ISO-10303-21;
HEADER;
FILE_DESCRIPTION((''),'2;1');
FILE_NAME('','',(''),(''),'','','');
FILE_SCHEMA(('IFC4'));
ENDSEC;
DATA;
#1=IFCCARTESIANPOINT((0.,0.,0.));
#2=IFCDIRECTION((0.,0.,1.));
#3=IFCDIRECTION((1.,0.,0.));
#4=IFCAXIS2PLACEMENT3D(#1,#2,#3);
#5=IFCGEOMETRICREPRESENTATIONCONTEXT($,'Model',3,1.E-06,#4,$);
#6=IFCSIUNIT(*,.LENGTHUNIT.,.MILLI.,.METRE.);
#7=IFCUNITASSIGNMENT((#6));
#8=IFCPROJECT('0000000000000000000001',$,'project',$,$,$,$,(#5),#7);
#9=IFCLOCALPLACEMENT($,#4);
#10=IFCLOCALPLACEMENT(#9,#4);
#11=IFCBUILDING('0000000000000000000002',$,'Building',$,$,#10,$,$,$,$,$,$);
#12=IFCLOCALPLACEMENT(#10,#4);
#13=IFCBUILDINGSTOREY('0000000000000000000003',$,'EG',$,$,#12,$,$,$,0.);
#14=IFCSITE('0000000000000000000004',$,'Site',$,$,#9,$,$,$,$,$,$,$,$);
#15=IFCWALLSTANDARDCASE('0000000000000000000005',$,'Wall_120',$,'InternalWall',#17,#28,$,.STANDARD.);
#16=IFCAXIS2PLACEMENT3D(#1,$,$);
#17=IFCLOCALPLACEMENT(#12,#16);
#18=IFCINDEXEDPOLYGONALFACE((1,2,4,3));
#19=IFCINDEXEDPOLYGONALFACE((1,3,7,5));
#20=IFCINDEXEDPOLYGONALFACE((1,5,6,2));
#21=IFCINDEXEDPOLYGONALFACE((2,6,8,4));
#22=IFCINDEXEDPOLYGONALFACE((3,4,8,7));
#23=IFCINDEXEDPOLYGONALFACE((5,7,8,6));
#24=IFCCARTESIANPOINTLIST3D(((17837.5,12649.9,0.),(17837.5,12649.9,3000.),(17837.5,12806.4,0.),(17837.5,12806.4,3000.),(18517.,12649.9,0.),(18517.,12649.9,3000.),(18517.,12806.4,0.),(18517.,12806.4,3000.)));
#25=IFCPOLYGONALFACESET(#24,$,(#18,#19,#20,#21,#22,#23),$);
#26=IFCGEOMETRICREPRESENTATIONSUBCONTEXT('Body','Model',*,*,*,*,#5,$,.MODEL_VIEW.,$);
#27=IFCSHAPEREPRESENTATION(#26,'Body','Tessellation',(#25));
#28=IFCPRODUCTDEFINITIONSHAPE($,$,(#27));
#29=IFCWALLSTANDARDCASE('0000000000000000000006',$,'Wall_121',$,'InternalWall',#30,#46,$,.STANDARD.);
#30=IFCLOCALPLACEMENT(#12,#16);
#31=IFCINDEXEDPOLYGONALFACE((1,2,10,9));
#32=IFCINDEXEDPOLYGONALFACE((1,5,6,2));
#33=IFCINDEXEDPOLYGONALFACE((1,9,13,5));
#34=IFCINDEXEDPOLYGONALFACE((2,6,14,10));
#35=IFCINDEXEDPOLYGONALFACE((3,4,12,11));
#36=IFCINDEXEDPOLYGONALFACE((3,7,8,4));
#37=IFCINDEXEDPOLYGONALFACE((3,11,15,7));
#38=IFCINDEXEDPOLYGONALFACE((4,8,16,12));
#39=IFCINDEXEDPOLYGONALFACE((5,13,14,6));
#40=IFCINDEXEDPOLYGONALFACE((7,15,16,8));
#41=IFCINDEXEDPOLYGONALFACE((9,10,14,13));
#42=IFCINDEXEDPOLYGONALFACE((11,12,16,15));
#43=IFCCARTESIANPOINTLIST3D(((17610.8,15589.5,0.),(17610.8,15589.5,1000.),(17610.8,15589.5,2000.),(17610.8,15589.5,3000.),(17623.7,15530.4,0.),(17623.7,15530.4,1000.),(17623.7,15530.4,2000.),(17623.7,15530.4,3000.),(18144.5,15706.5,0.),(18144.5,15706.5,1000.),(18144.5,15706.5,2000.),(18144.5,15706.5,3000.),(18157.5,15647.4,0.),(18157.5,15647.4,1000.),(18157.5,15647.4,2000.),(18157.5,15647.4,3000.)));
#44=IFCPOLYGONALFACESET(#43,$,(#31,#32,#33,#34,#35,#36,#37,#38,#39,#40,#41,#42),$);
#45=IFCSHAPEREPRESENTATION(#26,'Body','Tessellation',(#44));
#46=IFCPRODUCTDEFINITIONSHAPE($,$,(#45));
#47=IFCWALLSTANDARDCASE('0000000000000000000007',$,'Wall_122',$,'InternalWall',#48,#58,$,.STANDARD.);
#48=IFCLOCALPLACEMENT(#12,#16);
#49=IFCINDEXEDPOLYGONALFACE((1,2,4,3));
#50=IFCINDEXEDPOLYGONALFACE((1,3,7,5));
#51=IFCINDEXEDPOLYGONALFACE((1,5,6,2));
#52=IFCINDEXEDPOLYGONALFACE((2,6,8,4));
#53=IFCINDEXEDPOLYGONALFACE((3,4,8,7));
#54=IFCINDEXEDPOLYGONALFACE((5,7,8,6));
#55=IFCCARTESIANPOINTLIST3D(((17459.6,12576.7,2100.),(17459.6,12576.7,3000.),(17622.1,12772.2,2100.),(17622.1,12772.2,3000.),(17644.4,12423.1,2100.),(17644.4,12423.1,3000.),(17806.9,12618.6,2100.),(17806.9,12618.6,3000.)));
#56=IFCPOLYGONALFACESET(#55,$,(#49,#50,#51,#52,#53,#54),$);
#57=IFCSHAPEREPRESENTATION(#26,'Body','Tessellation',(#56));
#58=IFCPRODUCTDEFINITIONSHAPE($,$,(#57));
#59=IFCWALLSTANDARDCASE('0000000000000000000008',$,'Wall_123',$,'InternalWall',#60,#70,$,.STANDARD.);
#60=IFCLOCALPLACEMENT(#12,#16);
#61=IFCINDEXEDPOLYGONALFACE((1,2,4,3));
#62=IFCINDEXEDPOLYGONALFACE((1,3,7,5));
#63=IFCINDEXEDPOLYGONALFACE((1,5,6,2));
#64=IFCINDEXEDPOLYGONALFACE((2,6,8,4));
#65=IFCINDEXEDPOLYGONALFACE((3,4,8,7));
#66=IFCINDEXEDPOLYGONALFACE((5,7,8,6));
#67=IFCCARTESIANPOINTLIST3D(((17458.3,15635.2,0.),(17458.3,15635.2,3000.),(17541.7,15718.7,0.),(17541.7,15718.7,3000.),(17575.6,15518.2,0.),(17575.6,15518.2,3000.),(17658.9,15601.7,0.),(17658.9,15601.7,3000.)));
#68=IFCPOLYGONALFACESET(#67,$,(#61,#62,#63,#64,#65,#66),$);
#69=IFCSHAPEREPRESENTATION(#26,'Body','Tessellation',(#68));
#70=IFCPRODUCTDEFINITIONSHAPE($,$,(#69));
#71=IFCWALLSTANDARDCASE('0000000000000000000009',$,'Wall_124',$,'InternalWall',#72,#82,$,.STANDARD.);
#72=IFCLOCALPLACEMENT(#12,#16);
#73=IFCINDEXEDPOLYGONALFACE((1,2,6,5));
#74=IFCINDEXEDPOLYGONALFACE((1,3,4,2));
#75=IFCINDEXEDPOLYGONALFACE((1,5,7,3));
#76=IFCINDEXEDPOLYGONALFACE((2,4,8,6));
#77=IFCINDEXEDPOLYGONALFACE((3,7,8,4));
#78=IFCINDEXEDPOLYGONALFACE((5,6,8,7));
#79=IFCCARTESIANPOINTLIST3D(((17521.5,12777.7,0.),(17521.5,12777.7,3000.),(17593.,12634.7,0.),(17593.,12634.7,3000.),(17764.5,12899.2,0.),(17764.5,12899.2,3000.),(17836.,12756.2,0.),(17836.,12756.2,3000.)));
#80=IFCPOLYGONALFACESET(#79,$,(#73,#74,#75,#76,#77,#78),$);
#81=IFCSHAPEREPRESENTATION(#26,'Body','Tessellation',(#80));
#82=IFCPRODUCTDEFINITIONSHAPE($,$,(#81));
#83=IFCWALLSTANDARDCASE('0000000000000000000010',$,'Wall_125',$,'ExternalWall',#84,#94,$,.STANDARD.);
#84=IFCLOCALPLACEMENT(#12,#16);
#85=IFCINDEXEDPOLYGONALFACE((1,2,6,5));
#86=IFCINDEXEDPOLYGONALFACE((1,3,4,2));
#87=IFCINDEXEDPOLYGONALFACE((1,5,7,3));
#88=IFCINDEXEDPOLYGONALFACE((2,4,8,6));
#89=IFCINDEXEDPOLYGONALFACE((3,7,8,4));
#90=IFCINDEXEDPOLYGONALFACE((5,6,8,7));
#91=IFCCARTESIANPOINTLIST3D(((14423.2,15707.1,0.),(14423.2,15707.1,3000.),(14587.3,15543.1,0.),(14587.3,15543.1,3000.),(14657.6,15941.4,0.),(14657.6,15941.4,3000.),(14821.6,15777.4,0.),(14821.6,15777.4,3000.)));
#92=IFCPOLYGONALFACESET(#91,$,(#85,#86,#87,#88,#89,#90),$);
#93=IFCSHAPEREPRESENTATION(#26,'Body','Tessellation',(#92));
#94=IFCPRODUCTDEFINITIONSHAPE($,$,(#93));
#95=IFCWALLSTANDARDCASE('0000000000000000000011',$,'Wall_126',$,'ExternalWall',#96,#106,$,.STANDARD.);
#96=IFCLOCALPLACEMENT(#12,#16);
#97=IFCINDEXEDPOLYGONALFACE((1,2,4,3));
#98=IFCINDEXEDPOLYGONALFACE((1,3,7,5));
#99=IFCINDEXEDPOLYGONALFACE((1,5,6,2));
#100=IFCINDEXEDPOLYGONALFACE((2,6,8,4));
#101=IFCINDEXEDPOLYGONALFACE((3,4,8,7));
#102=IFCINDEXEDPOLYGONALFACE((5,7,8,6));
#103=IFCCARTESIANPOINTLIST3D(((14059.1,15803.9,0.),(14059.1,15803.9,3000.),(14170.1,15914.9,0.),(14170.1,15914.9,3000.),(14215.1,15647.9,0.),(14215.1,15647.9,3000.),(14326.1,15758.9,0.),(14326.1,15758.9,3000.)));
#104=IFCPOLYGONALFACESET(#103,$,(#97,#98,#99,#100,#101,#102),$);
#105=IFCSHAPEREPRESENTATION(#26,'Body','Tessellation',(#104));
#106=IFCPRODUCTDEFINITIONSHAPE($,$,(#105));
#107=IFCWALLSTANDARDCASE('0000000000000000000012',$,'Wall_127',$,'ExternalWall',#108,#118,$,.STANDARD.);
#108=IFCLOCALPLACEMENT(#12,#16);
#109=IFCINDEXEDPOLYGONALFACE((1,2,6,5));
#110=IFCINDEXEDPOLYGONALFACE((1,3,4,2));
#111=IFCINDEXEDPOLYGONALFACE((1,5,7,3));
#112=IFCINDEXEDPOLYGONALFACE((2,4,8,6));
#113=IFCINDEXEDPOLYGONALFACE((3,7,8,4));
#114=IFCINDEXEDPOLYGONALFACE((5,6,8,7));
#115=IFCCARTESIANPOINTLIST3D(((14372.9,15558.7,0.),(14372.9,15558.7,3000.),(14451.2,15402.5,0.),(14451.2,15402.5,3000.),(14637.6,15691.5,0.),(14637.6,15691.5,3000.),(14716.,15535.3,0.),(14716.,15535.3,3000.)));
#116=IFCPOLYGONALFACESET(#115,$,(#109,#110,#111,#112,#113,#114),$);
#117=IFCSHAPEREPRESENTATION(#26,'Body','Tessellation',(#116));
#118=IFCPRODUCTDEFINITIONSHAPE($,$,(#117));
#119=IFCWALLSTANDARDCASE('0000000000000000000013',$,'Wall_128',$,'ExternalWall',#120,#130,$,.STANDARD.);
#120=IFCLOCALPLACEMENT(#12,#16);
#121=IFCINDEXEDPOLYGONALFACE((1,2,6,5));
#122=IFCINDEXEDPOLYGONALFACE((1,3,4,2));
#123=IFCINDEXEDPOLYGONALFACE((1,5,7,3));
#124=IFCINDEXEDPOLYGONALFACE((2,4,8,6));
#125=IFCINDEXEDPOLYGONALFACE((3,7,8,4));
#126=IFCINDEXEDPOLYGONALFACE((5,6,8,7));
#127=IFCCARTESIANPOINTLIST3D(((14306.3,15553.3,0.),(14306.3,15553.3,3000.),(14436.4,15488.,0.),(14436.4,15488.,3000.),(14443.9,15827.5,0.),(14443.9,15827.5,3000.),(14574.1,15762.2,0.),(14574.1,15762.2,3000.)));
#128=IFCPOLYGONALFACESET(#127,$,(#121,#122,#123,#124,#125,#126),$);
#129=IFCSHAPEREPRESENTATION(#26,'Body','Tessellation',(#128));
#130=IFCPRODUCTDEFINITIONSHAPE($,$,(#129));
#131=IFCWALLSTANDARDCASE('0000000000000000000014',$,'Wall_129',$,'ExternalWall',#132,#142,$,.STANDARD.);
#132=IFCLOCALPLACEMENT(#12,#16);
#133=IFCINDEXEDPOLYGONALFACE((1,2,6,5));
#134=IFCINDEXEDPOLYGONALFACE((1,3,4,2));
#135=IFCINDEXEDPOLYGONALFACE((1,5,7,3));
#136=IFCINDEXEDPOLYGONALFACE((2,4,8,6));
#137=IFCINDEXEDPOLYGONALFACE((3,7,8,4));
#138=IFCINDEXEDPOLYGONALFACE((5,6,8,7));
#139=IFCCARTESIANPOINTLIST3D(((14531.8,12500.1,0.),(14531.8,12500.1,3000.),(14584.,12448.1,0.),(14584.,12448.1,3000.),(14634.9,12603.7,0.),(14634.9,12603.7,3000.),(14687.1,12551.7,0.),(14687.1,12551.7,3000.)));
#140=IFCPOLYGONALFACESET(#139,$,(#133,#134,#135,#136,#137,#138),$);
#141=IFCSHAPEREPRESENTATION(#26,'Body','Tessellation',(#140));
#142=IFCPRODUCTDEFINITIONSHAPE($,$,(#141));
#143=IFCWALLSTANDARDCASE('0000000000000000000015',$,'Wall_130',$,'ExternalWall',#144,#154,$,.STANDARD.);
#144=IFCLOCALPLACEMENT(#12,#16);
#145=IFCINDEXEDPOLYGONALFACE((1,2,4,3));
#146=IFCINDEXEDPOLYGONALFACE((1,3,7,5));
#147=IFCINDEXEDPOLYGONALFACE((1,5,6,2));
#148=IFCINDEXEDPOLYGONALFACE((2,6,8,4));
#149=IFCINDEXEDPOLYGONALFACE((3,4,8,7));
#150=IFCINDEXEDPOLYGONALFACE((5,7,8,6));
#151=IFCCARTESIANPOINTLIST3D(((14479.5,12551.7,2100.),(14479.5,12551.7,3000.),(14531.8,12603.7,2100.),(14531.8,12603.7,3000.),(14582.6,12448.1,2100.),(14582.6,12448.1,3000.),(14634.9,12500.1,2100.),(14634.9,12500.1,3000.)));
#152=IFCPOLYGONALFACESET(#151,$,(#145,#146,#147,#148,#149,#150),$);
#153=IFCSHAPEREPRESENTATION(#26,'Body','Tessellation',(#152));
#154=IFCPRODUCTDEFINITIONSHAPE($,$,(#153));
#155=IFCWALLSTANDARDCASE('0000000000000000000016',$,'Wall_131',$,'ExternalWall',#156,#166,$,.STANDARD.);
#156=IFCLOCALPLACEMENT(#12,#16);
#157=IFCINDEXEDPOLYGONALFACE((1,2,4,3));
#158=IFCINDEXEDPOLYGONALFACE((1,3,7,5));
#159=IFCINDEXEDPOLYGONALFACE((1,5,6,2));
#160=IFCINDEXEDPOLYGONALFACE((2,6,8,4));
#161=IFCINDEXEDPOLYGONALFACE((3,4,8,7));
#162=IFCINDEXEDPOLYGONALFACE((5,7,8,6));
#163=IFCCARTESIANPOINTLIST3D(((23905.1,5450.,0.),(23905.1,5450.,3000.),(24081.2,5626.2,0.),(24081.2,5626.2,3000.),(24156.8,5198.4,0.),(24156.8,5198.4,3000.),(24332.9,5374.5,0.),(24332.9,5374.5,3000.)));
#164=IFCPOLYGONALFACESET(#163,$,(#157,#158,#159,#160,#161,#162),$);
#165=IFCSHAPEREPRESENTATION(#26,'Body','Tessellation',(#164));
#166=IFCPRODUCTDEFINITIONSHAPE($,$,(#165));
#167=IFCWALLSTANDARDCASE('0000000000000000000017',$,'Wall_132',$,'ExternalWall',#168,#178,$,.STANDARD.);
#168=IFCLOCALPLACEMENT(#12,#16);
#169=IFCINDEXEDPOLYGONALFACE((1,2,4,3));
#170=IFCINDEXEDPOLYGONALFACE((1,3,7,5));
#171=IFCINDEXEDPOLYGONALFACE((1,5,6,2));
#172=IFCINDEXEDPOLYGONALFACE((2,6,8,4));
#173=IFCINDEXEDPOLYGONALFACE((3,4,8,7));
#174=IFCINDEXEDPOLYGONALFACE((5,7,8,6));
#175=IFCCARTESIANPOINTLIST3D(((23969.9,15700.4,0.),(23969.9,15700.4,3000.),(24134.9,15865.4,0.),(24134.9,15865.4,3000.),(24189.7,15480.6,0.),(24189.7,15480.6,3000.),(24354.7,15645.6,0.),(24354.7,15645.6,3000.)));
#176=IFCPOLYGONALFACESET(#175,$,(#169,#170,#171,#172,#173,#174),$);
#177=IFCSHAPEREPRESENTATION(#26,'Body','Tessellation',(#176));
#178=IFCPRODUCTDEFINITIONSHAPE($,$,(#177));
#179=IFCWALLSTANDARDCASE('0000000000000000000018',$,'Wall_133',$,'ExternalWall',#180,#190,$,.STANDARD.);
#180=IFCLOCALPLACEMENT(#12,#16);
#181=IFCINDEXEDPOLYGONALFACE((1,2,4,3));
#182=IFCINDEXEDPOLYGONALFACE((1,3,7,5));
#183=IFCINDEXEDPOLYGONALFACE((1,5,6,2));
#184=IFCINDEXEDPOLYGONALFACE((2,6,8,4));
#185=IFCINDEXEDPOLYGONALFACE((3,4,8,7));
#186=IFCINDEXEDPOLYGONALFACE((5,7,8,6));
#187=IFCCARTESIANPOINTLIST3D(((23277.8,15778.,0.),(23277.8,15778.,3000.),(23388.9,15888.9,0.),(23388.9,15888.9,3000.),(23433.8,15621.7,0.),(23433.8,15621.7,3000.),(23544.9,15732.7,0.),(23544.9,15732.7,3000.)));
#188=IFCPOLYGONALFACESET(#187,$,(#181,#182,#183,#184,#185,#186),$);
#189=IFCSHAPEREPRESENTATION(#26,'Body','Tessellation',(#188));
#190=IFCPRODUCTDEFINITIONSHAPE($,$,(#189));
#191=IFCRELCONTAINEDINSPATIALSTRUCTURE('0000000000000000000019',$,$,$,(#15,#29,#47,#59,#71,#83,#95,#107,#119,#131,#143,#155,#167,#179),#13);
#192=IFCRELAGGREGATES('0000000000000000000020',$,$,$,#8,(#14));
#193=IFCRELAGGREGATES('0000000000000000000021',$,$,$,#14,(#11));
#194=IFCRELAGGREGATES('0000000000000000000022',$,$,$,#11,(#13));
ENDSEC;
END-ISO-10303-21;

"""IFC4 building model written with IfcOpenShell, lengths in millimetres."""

from ifc_helpers import new_model, si_unit, frame, origin_with_axes, place, context, subcontext, project, spatial, rectangle, extrude, element, save


model = new_model("IFC4")

# Units and contexts
model_context = context("Model", 3, precision=1e-06, world=origin_with_axes())
body_context = subcontext(model_context, "Body", "Model", "MODEL_VIEW")
ifc_project = project(units=[si_unit("LENGTHUNIT", "METRE", prefix="MILLI")], contexts=[model_context])

# Site, building, storey
site_placement = place(None, origin_with_axes())
site = spatial("IfcSite", under=ifc_project, at=site_placement, Name="Site")
building_placement = place(site_placement, origin_with_axes())
building = spatial("IfcBuilding", under=site, at=building_placement, Name="Building")
storey_placement = place(building_placement, origin_with_axes())
storey = spatial("IfcBuildingStorey", under=building, at=storey_placement, Name="EG", Elevation=0.0)

# Wall
wall_1_placement = place(storey_placement, origin_with_axes())
element("IfcWallStandardCase", 1, at=wall_1_placement, inside=storey, Name="Wall_120", ObjectType="InternalWall", PredefinedType="STANDARD", context=body_context, shape_type="SweptSolid", body=[
    extrude(rectangle(XDim=679.6, YDim=156.5), frame((18177.3, 12728.2, 0.0), z_axis=(0.0, 0.0, 1.0), x_axis=(-1.0, 0.0, 0.0)), (0.0, 0.0, 1.0), 3000.0),
])

# Walls, openings
wall_2_placement = place(storey_placement, origin_with_axes())
wall_2 = element("IfcWallStandardCase", 2, at=wall_2_placement, inside=storey, Name="Wall_121", ObjectType="InternalWall", PredefinedType="STANDARD", context=body_context, shape_type="SweptSolid", body=[
    extrude(rectangle(XDim=546.4, YDim=60.5), frame((17884.1, 15618.4, 0.0), z_axis=(0.0, 0.0, 1.0), x_axis=(0.976807, 0.21412, 0.0)), (0.0, 0.0, 1.0), 3000.0),
])
opening_1_placement = place(wall_2_placement, origin_with_axes())
element("IfcOpeningElement", 3, at=opening_1_placement, inside=storey, cuts=wall_2, context=body_context, shape_type="SweptSolid", body=[
    extrude(rectangle(XDim=600.0, YDim=60.5), frame((17884.1, 15618.4, 1000.0), z_axis=(0.0, 0.0, 1.0), x_axis=(0.976807, 0.21412, 0.0)), (0.0, 0.0, 1.0), 1000.0),
])
wall_3_placement = place(storey_placement, origin_with_axes())
wall_3 = element("IfcWallStandardCase", 4, at=wall_3_placement, inside=storey, Name="Wall_122", ObjectType="InternalWall", PredefinedType="STANDARD", context=body_context, shape_type="SweptSolid", body=[
    extrude(rectangle(XDim=254.2, YDim=240.3), frame((17633.3, 12597.7, 0.0), z_axis=(0.0, 0.0, 1.0), x_axis=(-0.639217, -0.769027, 0.0)), (0.0, 0.0, 1.0), 3000.0),
])
opening_2_placement = place(wall_3_placement, origin_with_axes())
element("IfcOpeningElement", 5, at=opening_2_placement, inside=storey, cuts=wall_3, context=body_context, shape_type="SweptSolid", body=[
    extrude(rectangle(XDim=450.0, YDim=240.3), frame((17633.3, 12597.7, 0.0), z_axis=(0.0, 0.0, 1.0), x_axis=(-0.639217, -0.769027, 0.0)), (0.0, 0.0, 1.0), 2100.0),
])

# Walls
wall_4_placement = place(storey_placement, origin_with_axes())
element("IfcWallStandardCase", 6, at=wall_4_placement, inside=storey, Name="Wall_123", ObjectType="InternalWall", PredefinedType="STANDARD", context=body_context, shape_type="SweptSolid", body=[
    extrude(rectangle(XDim=165.6, YDim=118.0), frame((17558.6, 15618.4, 0.0), z_axis=(0.0, 0.0, 1.0), x_axis=(-0.707861, 0.706352, 0.0)), (0.0, 0.0, 1.0), 3000.0),
])
wall_5_placement = place(storey_placement, origin_with_axes())
element("IfcWallStandardCase", 7, at=wall_5_placement, inside=storey, Name="Wall_124", ObjectType="InternalWall", PredefinedType="STANDARD", context=body_context, shape_type="SweptSolid", body=[
    extrude(rectangle(XDim=159.9, YDim=271.7), frame((17678.8, 12766.9, 0.0), z_axis=(0.0, 0.0, 1.0), x_axis=(0.447214, -0.894427, 0.0)), (0.0, 0.0, 1.0), 3000.0),
])
wall_6_placement = place(storey_placement, origin_with_axes())
element("IfcWallStandardCase", 8, at=wall_6_placement, inside=storey, Name="Wall_125", ObjectType="ExternalWall", PredefinedType="STANDARD", context=body_context, shape_type="SweptSolid", body=[
    extrude(rectangle(XDim=331.4, YDim=231.9), frame((14622.4, 15742.3, 0.0), z_axis=(0.0, 0.0, 1.0), x_axis=(0.707107, 0.707107, 0.0)), (0.0, 0.0, 1.0), 3000.0),
])
wall_7_placement = place(storey_placement, origin_with_axes())
element("IfcWallStandardCase", 9, at=wall_7_placement, inside=storey, Name="Wall_126", ObjectType="ExternalWall", PredefinedType="STANDARD", context=body_context, shape_type="SweptSolid", body=[
    extrude(rectangle(XDim=220.6, YDim=157.0), frame((14192.6, 15781.4, 0.0), z_axis=(0.0, 0.0, 1.0), x_axis=(-0.707107, 0.707107, 0.0)), (0.0, 0.0, 1.0), 3000.0),
])
wall_8_placement = place(storey_placement, origin_with_axes())
element("IfcWallStandardCase", 10, at=wall_8_placement, inside=storey, Name="Wall_127", ObjectType="ExternalWall", PredefinedType="STANDARD", context=body_context, shape_type="SweptSolid", body=[
    extrude(rectangle(XDim=174.7, YDim=296.2), frame((14544.4, 15547.0, 0.0), z_axis=(0.0, 0.0, 1.0), x_axis=(-0.448358, 0.893854, 0.0)), (0.0, 0.0, 1.0), 3000.0),
])
wall_9_placement = place(storey_placement, origin_with_axes())
element("IfcWallStandardCase", 11, at=wall_9_placement, inside=storey, Name="Wall_128", ObjectType="ExternalWall", PredefinedType="STANDARD", context=body_context, shape_type="SweptSolid", body=[
    extrude(rectangle(XDim=145.6, YDim=306.8), frame((14440.2, 15657.8, 0.0), z_axis=(0.0, 0.0, 1.0), x_axis=(-0.89374, 0.448586, 0.0)), (0.0, 0.0, 1.0), 3000.0),
])
wall_10_placement = place(storey_placement, origin_with_axes())
element("IfcWallStandardCase", 12, at=wall_10_placement, inside=storey, Name="Wall_129", ObjectType="ExternalWall", PredefinedType="STANDARD", context=body_context, shape_type="SweptSolid", body=[
    extrude(rectangle(XDim=73.7, YDim=146.1), frame((14609.5, 12525.9, 0.0), z_axis=(0.0, 0.0, 1.0), x_axis=(0.7088, -0.705409, 0.0)), (0.0, 0.0, 1.0), 3000.0),
])

# Wall, opening
wall_11_placement = place(storey_placement, origin_with_axes())
wall_11 = element("IfcWallStandardCase", 13, at=wall_11_placement, inside=storey, Name="Wall_130", ObjectType="ExternalWall", PredefinedType="STANDARD", context=body_context, shape_type="SweptSolid", body=[
    extrude(rectangle(XDim=73.7, YDim=146.1), frame((14557.2, 12525.9, 0.0), z_axis=(0.0, 0.0, 1.0), x_axis=(-0.7088, -0.705409, 0.0)), (0.0, 0.0, 1.0), 3000.0),
])
opening_3_placement = place(wall_11_placement, origin_with_axes())
element("IfcOpeningElement", 14, at=opening_3_placement, inside=storey, cuts=wall_11, context=body_context, shape_type="SweptSolid", body=[
    extrude(rectangle(XDim=450.0, YDim=146.1), frame((14557.2, 12525.9, 0.0), z_axis=(0.0, 0.0, 1.0), x_axis=(-0.7088, -0.705409, 0.0)), (0.0, 0.0, 1.0), 2100.0),
])

# Walls
wall_12_placement = place(storey_placement, origin_with_axes())
element("IfcWallStandardCase", 15, at=wall_12_placement, inside=storey, Name="Wall_131", ObjectType="ExternalWall", PredefinedType="STANDARD", context=body_context, shape_type="SweptSolid", body=[
    extrude(rectangle(XDim=355.9, YDim=249.1), frame((24119.0, 5412.3, 0.0), z_axis=(0.0, 0.0, 1.0), x_axis=(0.707107, -0.707107, 0.0)), (0.0, 0.0, 1.0), 3000.0),
])
wall_13_placement = place(storey_placement, origin_with_axes())
element("IfcWallStandardCase", 16, at=wall_13_placement, inside=storey, Name="Wall_132", ObjectType="ExternalWall", PredefinedType="STANDARD", context=body_context, shape_type="SweptSolid", body=[
    extrude(rectangle(XDim=233.3, YDim=310.8), frame((24162.3, 15673.0, 0.0), z_axis=(0.0, 0.0, 1.0), x_axis=(0.707107, 0.707107, 0.0)), (0.0, 0.0, 1.0), 3000.0),
])
wall_14_placement = place(storey_placement, origin_with_axes())
element("IfcWallStandardCase", 17, at=wall_14_placement, inside=storey, Name="Wall_133", ObjectType="ExternalWall", PredefinedType="STANDARD", context=body_context, shape_type="SweptSolid", body=[
    extrude(rectangle(XDim=220.8, YDim=157.0), frame((23411.3, 15755.3, 0.0), z_axis=(0.0, 0.0, 1.0), x_axis=(-0.70654, 0.707673, 0.0)), (0.0, 0.0, 1.0), 3000.0),
])

save(model, "model.ifc")
